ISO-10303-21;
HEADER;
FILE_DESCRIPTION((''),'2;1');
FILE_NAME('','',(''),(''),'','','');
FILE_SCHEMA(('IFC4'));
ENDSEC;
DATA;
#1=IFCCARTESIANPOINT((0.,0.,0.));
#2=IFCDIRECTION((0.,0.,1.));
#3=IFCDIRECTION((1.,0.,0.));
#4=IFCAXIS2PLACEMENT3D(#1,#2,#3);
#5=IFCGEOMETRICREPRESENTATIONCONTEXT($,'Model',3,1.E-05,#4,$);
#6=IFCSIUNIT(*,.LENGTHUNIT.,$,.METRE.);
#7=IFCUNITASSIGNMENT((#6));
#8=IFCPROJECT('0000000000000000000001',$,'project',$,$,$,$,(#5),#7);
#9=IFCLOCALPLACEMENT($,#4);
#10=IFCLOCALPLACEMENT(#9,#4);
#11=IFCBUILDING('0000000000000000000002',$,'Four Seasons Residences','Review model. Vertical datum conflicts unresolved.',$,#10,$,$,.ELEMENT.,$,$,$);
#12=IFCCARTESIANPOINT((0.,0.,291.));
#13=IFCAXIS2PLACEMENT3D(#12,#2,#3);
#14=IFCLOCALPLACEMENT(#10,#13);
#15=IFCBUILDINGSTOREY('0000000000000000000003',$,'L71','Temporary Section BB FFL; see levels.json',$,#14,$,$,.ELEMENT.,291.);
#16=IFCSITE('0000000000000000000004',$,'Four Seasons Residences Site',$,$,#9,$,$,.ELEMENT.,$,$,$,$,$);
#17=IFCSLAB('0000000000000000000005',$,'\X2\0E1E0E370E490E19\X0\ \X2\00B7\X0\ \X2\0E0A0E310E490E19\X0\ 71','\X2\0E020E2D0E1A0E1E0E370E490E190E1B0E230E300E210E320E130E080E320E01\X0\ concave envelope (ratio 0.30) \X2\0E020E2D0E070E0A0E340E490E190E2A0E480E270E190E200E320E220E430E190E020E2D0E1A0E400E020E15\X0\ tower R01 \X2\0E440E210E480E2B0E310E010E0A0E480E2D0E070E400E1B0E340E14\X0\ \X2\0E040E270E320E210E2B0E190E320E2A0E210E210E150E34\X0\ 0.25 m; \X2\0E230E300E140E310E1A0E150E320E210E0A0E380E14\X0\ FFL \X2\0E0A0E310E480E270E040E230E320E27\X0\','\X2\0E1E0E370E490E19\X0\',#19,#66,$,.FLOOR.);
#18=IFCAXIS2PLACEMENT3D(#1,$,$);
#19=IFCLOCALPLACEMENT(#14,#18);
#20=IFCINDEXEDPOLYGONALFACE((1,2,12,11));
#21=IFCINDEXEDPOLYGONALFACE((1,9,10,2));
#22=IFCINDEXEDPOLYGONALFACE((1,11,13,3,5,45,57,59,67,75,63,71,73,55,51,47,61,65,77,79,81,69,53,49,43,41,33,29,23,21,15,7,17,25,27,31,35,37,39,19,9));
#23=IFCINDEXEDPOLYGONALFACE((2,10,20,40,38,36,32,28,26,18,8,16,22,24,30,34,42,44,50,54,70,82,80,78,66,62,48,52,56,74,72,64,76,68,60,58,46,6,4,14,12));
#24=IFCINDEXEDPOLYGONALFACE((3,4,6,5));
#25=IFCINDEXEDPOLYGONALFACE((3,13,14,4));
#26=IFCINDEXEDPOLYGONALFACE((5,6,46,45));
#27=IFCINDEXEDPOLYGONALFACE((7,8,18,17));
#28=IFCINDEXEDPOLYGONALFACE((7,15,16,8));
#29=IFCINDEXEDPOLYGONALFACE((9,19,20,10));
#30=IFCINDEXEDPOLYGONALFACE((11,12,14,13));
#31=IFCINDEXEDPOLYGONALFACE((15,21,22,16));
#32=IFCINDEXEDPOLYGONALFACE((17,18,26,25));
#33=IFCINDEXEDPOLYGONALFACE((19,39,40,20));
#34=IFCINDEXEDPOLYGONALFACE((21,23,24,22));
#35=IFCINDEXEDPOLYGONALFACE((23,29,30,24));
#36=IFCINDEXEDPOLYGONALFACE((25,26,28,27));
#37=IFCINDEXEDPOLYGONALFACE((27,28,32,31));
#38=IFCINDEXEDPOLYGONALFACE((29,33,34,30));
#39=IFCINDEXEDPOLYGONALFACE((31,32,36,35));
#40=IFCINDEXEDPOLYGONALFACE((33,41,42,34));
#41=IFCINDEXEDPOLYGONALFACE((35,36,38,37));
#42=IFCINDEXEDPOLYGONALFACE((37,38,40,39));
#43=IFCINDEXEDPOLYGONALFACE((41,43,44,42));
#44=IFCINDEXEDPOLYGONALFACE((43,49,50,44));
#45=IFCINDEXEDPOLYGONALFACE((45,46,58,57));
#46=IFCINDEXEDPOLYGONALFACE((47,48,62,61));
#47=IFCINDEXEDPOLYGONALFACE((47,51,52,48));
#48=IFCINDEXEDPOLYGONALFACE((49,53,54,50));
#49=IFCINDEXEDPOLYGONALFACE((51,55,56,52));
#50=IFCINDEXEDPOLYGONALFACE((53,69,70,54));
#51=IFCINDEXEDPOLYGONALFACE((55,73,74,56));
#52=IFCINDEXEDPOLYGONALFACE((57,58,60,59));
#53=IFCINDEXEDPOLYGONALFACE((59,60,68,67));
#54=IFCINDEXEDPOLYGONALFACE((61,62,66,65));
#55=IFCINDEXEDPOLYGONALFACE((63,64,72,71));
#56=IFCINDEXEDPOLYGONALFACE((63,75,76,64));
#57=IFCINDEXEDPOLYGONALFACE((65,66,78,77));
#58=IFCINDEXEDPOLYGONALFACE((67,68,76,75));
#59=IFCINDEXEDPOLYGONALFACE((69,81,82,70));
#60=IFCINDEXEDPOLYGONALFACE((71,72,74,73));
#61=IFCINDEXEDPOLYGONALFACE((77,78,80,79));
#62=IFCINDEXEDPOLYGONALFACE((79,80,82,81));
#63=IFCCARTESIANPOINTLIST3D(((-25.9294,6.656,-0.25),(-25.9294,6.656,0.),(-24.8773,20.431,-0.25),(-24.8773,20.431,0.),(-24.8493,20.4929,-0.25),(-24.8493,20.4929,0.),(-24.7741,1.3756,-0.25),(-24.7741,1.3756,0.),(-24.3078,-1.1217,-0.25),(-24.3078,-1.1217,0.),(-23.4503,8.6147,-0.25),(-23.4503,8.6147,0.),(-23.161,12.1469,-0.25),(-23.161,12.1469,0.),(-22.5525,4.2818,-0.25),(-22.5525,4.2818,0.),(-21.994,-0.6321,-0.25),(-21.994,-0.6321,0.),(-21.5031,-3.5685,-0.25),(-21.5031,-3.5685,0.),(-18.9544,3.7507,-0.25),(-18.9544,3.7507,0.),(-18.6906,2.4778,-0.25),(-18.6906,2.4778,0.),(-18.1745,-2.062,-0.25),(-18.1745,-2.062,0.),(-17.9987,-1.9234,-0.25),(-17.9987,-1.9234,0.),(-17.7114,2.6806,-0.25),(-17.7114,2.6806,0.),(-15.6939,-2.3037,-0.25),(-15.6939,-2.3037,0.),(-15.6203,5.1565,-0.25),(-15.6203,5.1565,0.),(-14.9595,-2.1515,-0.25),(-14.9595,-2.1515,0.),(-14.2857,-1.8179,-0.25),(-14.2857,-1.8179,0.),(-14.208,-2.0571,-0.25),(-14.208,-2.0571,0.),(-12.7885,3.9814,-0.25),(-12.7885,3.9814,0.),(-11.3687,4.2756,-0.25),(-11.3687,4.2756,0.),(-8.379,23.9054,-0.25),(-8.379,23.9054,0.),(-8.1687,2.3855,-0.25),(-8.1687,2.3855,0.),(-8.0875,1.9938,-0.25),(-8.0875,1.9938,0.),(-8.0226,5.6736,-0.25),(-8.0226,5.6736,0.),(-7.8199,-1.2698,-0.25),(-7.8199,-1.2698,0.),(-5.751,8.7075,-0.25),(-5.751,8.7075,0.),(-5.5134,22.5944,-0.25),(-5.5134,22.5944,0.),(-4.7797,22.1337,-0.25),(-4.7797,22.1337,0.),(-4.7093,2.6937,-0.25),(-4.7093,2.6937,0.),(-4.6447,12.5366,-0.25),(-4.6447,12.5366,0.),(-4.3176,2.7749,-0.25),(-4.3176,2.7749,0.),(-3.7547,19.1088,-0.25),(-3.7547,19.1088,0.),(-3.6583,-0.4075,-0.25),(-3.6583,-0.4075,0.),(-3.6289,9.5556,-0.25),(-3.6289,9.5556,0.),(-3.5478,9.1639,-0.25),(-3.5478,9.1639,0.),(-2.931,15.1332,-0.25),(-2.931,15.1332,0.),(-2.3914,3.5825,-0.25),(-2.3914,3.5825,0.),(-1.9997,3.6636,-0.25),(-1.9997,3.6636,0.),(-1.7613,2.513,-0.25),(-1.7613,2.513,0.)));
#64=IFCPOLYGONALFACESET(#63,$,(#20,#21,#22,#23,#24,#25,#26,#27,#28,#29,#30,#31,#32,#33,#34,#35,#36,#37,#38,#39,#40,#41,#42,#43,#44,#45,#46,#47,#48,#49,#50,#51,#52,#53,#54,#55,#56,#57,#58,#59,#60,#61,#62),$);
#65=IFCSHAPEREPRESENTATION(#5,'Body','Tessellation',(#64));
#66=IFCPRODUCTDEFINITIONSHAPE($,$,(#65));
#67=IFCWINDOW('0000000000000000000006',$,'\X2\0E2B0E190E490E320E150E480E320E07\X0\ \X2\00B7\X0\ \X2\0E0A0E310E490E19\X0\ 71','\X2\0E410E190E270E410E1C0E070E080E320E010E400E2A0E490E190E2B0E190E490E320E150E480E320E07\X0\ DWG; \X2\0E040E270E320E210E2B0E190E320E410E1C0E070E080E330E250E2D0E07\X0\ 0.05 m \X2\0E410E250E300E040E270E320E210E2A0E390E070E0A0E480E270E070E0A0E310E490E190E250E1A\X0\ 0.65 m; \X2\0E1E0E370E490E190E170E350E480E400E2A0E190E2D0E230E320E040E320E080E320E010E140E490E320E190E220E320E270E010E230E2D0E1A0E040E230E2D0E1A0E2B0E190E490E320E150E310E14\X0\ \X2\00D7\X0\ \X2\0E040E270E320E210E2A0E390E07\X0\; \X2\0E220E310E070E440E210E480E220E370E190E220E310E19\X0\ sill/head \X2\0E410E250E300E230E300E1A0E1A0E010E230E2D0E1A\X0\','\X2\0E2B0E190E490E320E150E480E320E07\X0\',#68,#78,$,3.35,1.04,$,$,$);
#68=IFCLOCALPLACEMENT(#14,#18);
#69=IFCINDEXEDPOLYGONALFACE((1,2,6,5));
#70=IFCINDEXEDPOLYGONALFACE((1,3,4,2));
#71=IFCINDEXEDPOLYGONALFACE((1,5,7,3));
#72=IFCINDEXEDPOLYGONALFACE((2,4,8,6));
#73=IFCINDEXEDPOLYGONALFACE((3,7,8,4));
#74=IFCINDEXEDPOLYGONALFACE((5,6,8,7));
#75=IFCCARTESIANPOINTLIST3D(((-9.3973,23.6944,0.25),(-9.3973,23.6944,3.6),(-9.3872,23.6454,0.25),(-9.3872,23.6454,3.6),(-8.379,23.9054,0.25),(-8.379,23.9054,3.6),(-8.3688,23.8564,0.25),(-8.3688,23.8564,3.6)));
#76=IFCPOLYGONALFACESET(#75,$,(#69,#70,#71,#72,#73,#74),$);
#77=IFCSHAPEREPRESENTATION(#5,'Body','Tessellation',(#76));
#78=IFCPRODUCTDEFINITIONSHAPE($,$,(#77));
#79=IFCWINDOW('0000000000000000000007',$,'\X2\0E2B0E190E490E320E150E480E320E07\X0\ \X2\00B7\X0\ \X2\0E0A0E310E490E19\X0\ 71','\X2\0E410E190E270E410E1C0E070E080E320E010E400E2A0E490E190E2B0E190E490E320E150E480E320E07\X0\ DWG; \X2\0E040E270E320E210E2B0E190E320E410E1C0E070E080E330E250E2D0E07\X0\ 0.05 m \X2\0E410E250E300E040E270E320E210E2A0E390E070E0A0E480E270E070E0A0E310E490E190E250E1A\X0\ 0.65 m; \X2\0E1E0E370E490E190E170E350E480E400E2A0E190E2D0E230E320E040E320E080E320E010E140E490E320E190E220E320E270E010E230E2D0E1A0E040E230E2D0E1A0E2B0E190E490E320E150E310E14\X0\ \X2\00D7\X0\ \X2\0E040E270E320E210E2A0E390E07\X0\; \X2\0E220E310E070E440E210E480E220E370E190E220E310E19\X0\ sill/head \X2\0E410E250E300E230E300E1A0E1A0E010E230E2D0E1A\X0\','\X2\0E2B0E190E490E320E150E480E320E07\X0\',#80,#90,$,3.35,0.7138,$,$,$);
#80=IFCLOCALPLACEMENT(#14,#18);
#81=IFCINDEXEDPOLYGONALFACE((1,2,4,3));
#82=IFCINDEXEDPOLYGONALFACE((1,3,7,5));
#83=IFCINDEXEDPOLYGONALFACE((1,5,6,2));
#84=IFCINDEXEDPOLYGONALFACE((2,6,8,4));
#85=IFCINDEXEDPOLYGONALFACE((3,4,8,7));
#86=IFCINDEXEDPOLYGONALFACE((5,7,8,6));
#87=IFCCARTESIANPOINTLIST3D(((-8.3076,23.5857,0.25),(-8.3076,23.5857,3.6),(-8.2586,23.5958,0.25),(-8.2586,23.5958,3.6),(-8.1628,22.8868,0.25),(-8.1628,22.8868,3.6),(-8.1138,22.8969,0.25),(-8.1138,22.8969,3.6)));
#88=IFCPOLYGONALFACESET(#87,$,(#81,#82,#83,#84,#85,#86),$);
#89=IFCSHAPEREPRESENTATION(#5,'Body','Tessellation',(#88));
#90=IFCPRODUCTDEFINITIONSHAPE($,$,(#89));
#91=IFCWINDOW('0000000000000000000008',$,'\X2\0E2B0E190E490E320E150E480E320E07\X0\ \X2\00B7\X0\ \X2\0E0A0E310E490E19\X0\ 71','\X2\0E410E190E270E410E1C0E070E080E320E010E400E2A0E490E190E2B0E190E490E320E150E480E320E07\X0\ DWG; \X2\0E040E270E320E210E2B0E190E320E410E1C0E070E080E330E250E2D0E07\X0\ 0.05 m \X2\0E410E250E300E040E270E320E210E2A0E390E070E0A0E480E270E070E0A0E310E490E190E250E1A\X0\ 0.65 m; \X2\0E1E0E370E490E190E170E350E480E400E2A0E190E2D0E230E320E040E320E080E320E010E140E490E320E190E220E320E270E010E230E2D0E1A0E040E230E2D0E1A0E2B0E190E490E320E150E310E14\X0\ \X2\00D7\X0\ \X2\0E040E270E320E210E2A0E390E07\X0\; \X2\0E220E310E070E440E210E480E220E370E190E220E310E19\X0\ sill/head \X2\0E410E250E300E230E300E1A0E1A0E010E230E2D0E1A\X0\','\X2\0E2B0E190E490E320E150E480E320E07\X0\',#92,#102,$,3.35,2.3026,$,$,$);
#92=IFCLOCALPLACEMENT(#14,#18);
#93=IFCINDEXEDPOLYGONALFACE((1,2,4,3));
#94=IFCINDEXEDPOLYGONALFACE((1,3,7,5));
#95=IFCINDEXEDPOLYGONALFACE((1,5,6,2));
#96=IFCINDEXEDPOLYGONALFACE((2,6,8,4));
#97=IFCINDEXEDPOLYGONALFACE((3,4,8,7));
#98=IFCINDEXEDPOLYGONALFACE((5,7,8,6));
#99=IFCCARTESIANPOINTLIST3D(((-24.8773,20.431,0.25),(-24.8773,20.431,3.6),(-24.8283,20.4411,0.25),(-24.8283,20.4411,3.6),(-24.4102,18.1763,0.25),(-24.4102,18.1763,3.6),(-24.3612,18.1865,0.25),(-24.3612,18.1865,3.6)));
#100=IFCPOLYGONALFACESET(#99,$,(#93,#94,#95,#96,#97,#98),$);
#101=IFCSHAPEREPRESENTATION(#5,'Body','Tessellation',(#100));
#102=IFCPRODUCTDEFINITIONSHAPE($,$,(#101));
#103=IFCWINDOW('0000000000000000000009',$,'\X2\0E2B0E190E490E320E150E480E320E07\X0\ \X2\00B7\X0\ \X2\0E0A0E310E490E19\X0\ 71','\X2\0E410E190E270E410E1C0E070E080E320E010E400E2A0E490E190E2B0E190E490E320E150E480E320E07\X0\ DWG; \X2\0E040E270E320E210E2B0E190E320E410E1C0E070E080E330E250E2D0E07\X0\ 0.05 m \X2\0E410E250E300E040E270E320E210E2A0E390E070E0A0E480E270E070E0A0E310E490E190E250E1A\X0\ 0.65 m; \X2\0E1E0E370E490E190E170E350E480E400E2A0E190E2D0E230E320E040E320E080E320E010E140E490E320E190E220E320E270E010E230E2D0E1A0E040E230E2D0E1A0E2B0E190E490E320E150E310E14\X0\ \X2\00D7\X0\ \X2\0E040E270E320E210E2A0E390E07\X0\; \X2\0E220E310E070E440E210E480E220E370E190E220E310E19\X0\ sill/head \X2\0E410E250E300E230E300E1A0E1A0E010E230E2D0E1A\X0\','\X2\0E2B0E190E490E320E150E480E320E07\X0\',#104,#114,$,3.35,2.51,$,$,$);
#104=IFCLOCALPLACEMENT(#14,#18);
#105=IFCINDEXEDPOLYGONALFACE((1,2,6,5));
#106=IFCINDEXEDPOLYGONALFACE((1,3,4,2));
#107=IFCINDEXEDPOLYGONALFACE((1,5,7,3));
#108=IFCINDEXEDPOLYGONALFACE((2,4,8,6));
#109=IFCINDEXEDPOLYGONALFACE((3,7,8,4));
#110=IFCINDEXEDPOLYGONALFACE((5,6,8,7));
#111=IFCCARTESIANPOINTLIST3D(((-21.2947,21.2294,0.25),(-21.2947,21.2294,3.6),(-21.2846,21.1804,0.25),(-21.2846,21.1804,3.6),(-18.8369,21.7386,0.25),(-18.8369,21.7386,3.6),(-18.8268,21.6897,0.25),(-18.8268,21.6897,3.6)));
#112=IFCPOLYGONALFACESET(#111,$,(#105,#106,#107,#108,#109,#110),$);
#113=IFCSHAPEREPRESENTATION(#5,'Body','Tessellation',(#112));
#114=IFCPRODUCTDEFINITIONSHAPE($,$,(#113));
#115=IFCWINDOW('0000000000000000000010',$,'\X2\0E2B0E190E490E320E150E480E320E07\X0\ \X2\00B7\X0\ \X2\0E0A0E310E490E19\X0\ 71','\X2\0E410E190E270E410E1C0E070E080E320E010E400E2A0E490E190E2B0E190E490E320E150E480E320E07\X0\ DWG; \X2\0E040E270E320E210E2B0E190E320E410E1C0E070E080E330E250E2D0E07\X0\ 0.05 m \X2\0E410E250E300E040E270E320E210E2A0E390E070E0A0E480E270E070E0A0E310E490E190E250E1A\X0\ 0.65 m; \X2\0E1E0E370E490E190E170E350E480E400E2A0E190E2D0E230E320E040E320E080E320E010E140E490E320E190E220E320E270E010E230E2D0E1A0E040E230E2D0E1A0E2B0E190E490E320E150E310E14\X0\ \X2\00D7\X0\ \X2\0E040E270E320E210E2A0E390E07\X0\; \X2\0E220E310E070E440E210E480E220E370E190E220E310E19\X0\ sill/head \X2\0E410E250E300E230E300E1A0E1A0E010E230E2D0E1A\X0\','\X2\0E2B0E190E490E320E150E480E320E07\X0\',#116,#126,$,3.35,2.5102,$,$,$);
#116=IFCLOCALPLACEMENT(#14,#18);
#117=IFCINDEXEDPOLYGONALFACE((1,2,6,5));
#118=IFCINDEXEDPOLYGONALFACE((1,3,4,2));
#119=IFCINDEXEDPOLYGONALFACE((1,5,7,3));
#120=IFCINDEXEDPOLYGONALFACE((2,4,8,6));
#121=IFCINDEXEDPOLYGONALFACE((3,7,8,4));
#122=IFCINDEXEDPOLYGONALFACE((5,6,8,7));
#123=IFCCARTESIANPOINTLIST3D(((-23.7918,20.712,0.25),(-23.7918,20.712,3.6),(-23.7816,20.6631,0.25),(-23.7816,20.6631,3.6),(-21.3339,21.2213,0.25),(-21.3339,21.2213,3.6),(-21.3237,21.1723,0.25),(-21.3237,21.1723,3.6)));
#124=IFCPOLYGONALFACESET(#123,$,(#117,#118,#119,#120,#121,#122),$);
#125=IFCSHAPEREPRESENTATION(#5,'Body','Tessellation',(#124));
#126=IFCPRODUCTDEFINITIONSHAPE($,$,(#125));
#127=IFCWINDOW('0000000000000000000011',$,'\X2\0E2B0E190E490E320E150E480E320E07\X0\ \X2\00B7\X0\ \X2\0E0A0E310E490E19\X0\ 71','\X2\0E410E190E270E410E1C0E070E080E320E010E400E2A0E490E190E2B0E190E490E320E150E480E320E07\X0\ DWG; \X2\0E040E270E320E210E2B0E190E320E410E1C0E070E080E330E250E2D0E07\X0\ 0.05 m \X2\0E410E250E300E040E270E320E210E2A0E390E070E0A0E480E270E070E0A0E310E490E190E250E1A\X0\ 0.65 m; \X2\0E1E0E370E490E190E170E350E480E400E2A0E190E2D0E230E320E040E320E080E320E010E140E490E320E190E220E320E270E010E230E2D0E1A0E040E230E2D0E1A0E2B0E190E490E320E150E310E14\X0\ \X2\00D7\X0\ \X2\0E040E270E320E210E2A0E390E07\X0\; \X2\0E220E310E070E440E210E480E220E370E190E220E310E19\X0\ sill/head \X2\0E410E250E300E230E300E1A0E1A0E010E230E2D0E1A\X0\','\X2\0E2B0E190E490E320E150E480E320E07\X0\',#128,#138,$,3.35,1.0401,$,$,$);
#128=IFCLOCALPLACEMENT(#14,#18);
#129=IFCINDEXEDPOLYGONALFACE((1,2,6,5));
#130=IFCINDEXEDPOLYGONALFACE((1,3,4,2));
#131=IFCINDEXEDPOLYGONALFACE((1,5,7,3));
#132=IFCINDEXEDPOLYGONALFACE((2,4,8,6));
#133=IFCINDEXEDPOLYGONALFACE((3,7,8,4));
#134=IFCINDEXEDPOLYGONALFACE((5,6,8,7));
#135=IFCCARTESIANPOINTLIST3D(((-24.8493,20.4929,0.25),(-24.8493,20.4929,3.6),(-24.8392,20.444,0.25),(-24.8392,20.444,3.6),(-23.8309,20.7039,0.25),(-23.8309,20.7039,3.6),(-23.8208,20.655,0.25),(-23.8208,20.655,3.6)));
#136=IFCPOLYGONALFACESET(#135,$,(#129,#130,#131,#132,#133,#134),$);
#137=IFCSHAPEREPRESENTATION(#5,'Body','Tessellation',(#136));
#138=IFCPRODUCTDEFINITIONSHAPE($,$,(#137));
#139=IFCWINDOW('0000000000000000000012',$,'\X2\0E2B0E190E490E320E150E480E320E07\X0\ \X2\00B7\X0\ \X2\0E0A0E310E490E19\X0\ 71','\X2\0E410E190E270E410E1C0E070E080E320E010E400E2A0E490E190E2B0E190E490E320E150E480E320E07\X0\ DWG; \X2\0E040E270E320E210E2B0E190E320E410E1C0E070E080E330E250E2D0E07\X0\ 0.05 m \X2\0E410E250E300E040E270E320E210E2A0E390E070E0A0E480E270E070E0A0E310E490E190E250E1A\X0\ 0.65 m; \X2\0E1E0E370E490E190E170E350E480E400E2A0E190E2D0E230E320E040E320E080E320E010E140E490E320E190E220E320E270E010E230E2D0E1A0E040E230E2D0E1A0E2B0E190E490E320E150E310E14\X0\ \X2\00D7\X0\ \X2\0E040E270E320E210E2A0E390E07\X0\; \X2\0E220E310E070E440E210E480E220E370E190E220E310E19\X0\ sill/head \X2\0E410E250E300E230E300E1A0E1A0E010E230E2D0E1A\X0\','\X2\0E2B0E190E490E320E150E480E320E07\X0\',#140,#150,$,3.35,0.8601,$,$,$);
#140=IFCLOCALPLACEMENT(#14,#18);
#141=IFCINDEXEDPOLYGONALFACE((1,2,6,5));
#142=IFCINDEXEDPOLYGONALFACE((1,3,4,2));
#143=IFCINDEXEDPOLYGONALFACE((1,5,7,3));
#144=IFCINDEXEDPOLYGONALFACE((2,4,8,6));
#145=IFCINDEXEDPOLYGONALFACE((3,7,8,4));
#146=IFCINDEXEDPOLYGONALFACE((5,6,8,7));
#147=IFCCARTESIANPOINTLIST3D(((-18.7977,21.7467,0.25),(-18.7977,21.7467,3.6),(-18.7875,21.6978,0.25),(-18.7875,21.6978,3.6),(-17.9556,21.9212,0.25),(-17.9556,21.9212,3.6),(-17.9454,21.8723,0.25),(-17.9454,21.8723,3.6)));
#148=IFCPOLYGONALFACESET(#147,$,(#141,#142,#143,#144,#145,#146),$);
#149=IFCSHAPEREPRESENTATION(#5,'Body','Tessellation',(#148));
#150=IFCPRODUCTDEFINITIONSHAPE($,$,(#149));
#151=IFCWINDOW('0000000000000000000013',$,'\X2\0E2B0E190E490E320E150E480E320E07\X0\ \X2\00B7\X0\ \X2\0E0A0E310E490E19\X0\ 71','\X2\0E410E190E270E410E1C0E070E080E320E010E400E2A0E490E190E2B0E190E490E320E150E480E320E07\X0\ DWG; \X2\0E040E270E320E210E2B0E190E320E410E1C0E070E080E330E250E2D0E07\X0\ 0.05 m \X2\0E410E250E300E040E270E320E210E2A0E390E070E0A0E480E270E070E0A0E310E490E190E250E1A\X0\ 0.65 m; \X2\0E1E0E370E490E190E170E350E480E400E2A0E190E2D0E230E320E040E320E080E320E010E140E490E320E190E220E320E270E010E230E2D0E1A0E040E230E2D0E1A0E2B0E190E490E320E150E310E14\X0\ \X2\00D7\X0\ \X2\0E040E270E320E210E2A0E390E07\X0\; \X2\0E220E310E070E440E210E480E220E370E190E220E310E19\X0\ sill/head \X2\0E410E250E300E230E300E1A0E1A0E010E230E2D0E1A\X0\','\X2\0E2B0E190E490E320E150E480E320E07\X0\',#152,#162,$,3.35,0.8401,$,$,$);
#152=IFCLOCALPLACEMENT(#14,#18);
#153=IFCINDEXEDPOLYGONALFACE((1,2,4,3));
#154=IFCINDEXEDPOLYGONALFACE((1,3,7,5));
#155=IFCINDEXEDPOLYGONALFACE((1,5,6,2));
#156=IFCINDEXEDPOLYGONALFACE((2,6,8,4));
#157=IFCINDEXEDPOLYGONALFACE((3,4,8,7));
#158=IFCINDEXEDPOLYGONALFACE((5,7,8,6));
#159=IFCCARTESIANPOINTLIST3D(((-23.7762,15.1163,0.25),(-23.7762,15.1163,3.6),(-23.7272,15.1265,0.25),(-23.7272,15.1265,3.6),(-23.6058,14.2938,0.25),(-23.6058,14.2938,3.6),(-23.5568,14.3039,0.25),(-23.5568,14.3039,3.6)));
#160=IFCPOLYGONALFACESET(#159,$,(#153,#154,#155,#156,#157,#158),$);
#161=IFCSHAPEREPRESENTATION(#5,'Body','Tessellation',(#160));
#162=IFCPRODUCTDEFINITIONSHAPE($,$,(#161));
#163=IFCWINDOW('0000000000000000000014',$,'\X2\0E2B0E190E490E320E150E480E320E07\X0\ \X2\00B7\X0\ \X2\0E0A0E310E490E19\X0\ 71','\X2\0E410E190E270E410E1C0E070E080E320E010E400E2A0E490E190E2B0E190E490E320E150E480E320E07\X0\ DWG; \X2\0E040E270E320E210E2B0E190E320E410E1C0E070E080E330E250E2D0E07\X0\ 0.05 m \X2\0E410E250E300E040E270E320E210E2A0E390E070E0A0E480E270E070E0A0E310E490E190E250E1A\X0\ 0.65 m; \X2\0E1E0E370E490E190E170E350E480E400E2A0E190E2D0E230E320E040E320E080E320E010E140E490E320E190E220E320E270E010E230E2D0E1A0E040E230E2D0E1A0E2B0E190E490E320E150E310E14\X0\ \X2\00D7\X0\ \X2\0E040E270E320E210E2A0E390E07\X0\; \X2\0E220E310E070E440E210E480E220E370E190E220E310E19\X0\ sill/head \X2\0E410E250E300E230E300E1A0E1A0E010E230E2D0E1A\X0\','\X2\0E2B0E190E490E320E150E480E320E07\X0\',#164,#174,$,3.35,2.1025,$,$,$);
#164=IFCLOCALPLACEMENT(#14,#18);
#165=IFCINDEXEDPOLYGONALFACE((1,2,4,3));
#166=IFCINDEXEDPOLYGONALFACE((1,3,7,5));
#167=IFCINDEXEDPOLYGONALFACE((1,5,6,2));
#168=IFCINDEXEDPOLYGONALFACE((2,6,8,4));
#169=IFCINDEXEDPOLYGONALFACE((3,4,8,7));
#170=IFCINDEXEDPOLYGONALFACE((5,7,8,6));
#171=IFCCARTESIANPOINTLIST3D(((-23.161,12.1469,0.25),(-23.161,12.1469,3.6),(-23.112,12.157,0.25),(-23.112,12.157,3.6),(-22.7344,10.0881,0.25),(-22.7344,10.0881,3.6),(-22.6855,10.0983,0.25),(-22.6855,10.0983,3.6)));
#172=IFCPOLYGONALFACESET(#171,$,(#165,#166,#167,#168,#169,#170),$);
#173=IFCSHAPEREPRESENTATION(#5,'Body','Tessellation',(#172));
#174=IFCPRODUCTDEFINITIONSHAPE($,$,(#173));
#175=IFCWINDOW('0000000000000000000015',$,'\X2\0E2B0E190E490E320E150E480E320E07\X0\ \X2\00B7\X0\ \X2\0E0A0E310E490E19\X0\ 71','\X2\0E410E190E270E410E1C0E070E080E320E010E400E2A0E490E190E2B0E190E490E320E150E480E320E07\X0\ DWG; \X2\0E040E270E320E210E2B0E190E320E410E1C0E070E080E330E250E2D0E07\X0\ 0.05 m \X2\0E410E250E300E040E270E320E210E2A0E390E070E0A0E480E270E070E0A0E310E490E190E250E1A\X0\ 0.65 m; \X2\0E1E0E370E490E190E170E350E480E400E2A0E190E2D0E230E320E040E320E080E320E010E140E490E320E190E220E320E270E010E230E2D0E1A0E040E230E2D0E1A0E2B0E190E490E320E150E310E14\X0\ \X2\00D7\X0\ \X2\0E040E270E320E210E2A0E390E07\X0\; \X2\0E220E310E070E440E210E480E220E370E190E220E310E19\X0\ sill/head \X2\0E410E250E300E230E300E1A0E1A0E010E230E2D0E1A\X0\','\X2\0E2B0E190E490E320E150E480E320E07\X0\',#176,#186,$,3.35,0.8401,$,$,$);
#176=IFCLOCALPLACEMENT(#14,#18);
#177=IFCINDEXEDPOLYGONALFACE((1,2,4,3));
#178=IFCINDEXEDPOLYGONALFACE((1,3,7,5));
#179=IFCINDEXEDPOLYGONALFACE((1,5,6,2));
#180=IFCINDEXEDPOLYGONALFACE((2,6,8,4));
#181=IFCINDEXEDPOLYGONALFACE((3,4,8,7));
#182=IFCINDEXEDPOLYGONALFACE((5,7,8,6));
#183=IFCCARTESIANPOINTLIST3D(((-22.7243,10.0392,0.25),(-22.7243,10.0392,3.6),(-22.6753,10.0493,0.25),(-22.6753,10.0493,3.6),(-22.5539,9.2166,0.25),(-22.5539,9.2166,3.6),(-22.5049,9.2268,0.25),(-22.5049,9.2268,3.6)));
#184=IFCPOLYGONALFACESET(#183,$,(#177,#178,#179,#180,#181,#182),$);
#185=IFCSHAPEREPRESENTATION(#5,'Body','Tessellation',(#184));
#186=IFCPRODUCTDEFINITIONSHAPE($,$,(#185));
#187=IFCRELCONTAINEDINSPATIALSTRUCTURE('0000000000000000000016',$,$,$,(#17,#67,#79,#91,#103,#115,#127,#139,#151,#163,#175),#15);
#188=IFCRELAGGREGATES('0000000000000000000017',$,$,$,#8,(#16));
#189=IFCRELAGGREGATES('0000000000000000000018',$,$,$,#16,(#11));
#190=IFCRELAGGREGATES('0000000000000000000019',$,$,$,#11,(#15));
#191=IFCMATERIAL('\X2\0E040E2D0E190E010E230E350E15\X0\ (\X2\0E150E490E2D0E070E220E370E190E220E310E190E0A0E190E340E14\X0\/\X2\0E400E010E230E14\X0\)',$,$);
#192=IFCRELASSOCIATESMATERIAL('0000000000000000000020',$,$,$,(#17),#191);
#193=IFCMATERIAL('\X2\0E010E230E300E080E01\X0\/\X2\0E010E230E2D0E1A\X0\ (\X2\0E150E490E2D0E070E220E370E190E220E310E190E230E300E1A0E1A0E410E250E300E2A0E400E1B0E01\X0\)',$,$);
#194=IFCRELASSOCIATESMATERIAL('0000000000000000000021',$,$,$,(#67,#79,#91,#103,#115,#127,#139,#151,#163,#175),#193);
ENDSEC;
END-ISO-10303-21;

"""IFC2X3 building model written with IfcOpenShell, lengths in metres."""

from ifc_helpers import new_model, si_unit, frame, origin_with_axes, place, context, project, spatial, polyline, outline, extrude, material, element, save


model = new_model("IFC2X3")

# Units and contexts
model_context = context("Model", 3, precision=1e-05, world=origin_with_axes())
ifc_project = project(units=[si_unit("LENGTHUNIT", "METRE")], contexts=[model_context])

# Site, building, storey
site_placement = place(None, origin_with_axes())
site = spatial("IfcSite", under=ifc_project, at=site_placement, Name="Four Seasons Residences Site", CompositionType="ELEMENT")
building_placement = place(site_placement, origin_with_axes())
building = spatial("IfcBuilding", under=site, at=building_placement, Name="Four Seasons Residences", Description="Review model. Vertical datum conflicts unresolved.", CompositionType="ELEMENT")
storey_placement = place(building_placement, frame((0.0, 0.0, 291.0), z_axis=(0.0, 0.0, 1.0), x_axis=(1.0, 0.0, 0.0)))
storey = spatial("IfcBuildingStorey", under=building, at=storey_placement, Name="L71", Description="Temporary Section BB FFL; see levels.json", CompositionType="ELEMENT", Elevation=291.0)

# Slab
ifc_material_1 = material(Name="คอนกรีต (ต้องยืนยันชนิด/เกรด)")
slab_placement = place(storey_placement, origin_with_axes())
element("IfcSlab", 1, at=slab_placement, inside=storey, material=ifc_material_1, Name="พื้น · ชั้น 71", Description="ขอบพื้นประมาณจาก concave envelope (ratio 0.30) ของชิ้นส่วนภายในขอบเขต tower R01 ไม่หักช่องเปิด ความหนาสมมติ 0.25 m; ระดับตามชุด FFL ชั่วคราว", ObjectType="พื้น", PredefinedType="FLOOR", context=model_context, shape_type="SweptSolid", body=[
    extrude(outline(polyline([(-24.8773, 20.431), (-24.8493, 20.4929), (-8.379, 23.9054), (-5.5134, 22.5944), (-4.7797, 22.1337), (-3.7547, 19.1088), (-2.931, 15.1332), (-4.6447, 12.5366), (-3.6289, 9.5556), (-3.5478, 9.1639), (-5.751, 8.7075), (-8.0226, 5.6736), (-8.1687, 2.3855), (-4.7093, 2.6937), (-4.3176, 2.7749), (-2.3914, 3.5825), (-1.9997, 3.6636), (-1.7613, 2.513), (-3.6583, -0.4075), (-7.8199, -1.2698), (-8.0875, 1.9938), (-11.3687, 4.2756), (-12.7885, 3.9814), (-15.6203, 5.1565), (-17.7114, 2.6806), (-18.6906, 2.4778), (-18.9544, 3.7507), (-22.5525, 4.2818), (-24.7741, 1.3756), (-21.994, -0.6321), (-18.1745, -2.062), (-17.9987, -1.9234), (-15.6939, -2.3037), (-14.9595, -2.1515), (-14.2857, -1.8179), (-14.208, -2.0571), (-21.5031, -3.5685), (-24.3078, -1.1217), (-25.9294, 6.656), (-23.4503, 8.6147), (-23.161, 12.1469), (-24.8773, 20.431)])), frame((0.0, 0.0, -0.25), z_axis=(0.0, 0.0, 1.0), x_axis=(1.0, 0.0, 0.0)), (0.0, 0.0, 1.0), 0.25),
])

# Windows
ifc_material_2 = material(Name="กระจก/กรอบ (ต้องยืนยันระบบและสเปก)")
window_1_placement = place(storey_placement, origin_with_axes())
element("IfcWindow", 2, at=window_1_placement, inside=storey, material=ifc_material_2, Name="หน้าต่าง · ชั้น 71", Description="แนวแผงจากเส้นหน้าต่าง DWG; ความหนาแผงจำลอง 0.05 m และความสูงช่วงชั้นลบ 0.65 m; พื้นที่เสนอราคาจากด้านยาวกรอบครอบหน้าตัด × ความสูง; ยังไม่ยืนยัน sill/head และระบบกรอบ", ObjectType="หน้าต่าง", OverallHeight=3.35, OverallWidth=1.04, context=model_context, shape_type="SweptSolid", body=[
    extrude(outline(polyline([(-8.379, 23.9054), (-8.3688, 23.8564), (-9.3872, 23.6454), (-9.3973, 23.6944), (-8.379, 23.9054)])), frame((0.0, 0.0, 0.25), z_axis=(0.0, 0.0, 1.0), x_axis=(1.0, 0.0, 0.0)), (0.0, 0.0, 1.0), 3.35),
])
window_2_placement = place(storey_placement, origin_with_axes())
element("IfcWindow", 3, at=window_2_placement, inside=storey, material=ifc_material_2, Name="หน้าต่าง · ชั้น 71", Description="แนวแผงจากเส้นหน้าต่าง DWG; ความหนาแผงจำลอง 0.05 m และความสูงช่วงชั้นลบ 0.65 m; พื้นที่เสนอราคาจากด้านยาวกรอบครอบหน้าตัด × ความสูง; ยังไม่ยืนยัน sill/head และระบบกรอบ", ObjectType="หน้าต่าง", OverallHeight=3.35, OverallWidth=0.7138, context=model_context, shape_type="SweptSolid", body=[
    extrude(outline(polyline([(-8.3076, 23.5857), (-8.2586, 23.5958), (-8.1138, 22.8969), (-8.1628, 22.8868), (-8.3076, 23.5857)])), frame((0.0, 0.0, 0.25), z_axis=(0.0, 0.0, 1.0), x_axis=(1.0, 0.0, 0.0)), (0.0, 0.0, 1.0), 3.35),
])
window_3_placement = place(storey_placement, origin_with_axes())
element("IfcWindow", 4, at=window_3_placement, inside=storey, material=ifc_material_2, Name="หน้าต่าง · ชั้น 71", Description="แนวแผงจากเส้นหน้าต่าง DWG; ความหนาแผงจำลอง 0.05 m และความสูงช่วงชั้นลบ 0.65 m; พื้นที่เสนอราคาจากด้านยาวกรอบครอบหน้าตัด × ความสูง; ยังไม่ยืนยัน sill/head และระบบกรอบ", ObjectType="หน้าต่าง", OverallHeight=3.35, OverallWidth=2.3026, context=model_context, shape_type="SweptSolid", body=[
    extrude(outline(polyline([(-24.8773, 20.431), (-24.8283, 20.4411), (-24.3612, 18.1865), (-24.4102, 18.1763), (-24.8773, 20.431)])), frame((0.0, 0.0, 0.25), z_axis=(0.0, 0.0, 1.0), x_axis=(1.0, 0.0, 0.0)), (0.0, 0.0, 1.0), 3.35),
])
window_4_placement = place(storey_placement, origin_with_axes())
element("IfcWindow", 5, at=window_4_placement, inside=storey, material=ifc_material_2, Name="หน้าต่าง · ชั้น 71", Description="แนวแผงจากเส้นหน้าต่าง DWG; ความหนาแผงจำลอง 0.05 m และความสูงช่วงชั้นลบ 0.65 m; พื้นที่เสนอราคาจากด้านยาวกรอบครอบหน้าตัด × ความสูง; ยังไม่ยืนยัน sill/head และระบบกรอบ", ObjectType="หน้าต่าง", OverallHeight=3.35, OverallWidth=2.51, context=model_context, shape_type="SweptSolid", body=[
    extrude(outline(polyline([(-21.2846, 21.1804), (-21.2947, 21.2294), (-18.8369, 21.7386), (-18.8268, 21.6897), (-21.2846, 21.1804)])), frame((0.0, 0.0, 0.25), z_axis=(0.0, 0.0, 1.0), x_axis=(1.0, 0.0, 0.0)), (0.0, 0.0, 1.0), 3.35),
])
window_5_placement = place(storey_placement, origin_with_axes())
element("IfcWindow", 6, at=window_5_placement, inside=storey, material=ifc_material_2, Name="หน้าต่าง · ชั้น 71", Description="แนวแผงจากเส้นหน้าต่าง DWG; ความหนาแผงจำลอง 0.05 m และความสูงช่วงชั้นลบ 0.65 m; พื้นที่เสนอราคาจากด้านยาวกรอบครอบหน้าตัด × ความสูง; ยังไม่ยืนยัน sill/head และระบบกรอบ", ObjectType="หน้าต่าง", OverallHeight=3.35, OverallWidth=2.5102, context=model_context, shape_type="SweptSolid", body=[
    extrude(outline(polyline([(-23.7816, 20.6631), (-23.7918, 20.712), (-21.3339, 21.2213), (-21.3237, 21.1723), (-23.7816, 20.6631)])), frame((0.0, 0.0, 0.25), z_axis=(0.0, 0.0, 1.0), x_axis=(1.0, 0.0, 0.0)), (0.0, 0.0, 1.0), 3.35),
])
window_6_placement = place(storey_placement, origin_with_axes())
element("IfcWindow", 7, at=window_6_placement, inside=storey, material=ifc_material_2, Name="หน้าต่าง · ชั้น 71", Description="แนวแผงจากเส้นหน้าต่าง DWG; ความหนาแผงจำลอง 0.05 m และความสูงช่วงชั้นลบ 0.65 m; พื้นที่เสนอราคาจากด้านยาวกรอบครอบหน้าตัด × ความสูง; ยังไม่ยืนยัน sill/head และระบบกรอบ", ObjectType="หน้าต่าง", OverallHeight=3.35, OverallWidth=1.0401, context=model_context, shape_type="SweptSolid", body=[
    extrude(outline(polyline([(-24.8392, 20.444), (-24.8493, 20.4929), (-23.8309, 20.7039), (-23.8208, 20.655), (-24.8392, 20.444)])), frame((0.0, 0.0, 0.25), z_axis=(0.0, 0.0, 1.0), x_axis=(1.0, 0.0, 0.0)), (0.0, 0.0, 1.0), 3.35),
])
window_7_placement = place(storey_placement, origin_with_axes())
element("IfcWindow", 8, at=window_7_placement, inside=storey, material=ifc_material_2, Name="หน้าต่าง · ชั้น 71", Description="แนวแผงจากเส้นหน้าต่าง DWG; ความหนาแผงจำลอง 0.05 m และความสูงช่วงชั้นลบ 0.65 m; พื้นที่เสนอราคาจากด้านยาวกรอบครอบหน้าตัด × ความสูง; ยังไม่ยืนยัน sill/head และระบบกรอบ", ObjectType="หน้าต่าง", OverallHeight=3.35, OverallWidth=0.8601, context=model_context, shape_type="SweptSolid", body=[
    extrude(outline(polyline([(-17.9556, 21.9212), (-17.9454, 21.8723), (-18.7875, 21.6978), (-18.7977, 21.7467), (-17.9556, 21.9212)])), frame((0.0, 0.0, 0.25), z_axis=(0.0, 0.0, 1.0), x_axis=(1.0, 0.0, 0.0)), (0.0, 0.0, 1.0), 3.35),
])
window_8_placement = place(storey_placement, origin_with_axes())
element("IfcWindow", 9, at=window_8_placement, inside=storey, material=ifc_material_2, Name="หน้าต่าง · ชั้น 71", Description="แนวแผงจากเส้นหน้าต่าง DWG; ความหนาแผงจำลอง 0.05 m และความสูงช่วงชั้นลบ 0.65 m; พื้นที่เสนอราคาจากด้านยาวกรอบครอบหน้าตัด × ความสูง; ยังไม่ยืนยัน sill/head และระบบกรอบ", ObjectType="หน้าต่าง", OverallHeight=3.35, OverallWidth=0.8401, context=model_context, shape_type="SweptSolid", body=[
    extrude(outline(polyline([(-23.7762, 15.1163), (-23.7272, 15.1265), (-23.5568, 14.3039), (-23.6058, 14.2938), (-23.7762, 15.1163)])), frame((0.0, 0.0, 0.25), z_axis=(0.0, 0.0, 1.0), x_axis=(1.0, 0.0, 0.0)), (0.0, 0.0, 1.0), 3.35),
])
window_9_placement = place(storey_placement, origin_with_axes())
element("IfcWindow", 10, at=window_9_placement, inside=storey, material=ifc_material_2, Name="หน้าต่าง · ชั้น 71", Description="แนวแผงจากเส้นหน้าต่าง DWG; ความหนาแผงจำลอง 0.05 m และความสูงช่วงชั้นลบ 0.65 m; พื้นที่เสนอราคาจากด้านยาวกรอบครอบหน้าตัด × ความสูง; ยังไม่ยืนยัน sill/head และระบบกรอบ", ObjectType="หน้าต่าง", OverallHeight=3.35, OverallWidth=2.1025, context=model_context, shape_type="SweptSolid", body=[
    extrude(outline(polyline([(-23.161, 12.1469), (-23.112, 12.157), (-22.6855, 10.0983), (-22.7344, 10.0881), (-23.161, 12.1469)])), frame((0.0, 0.0, 0.25), z_axis=(0.0, 0.0, 1.0), x_axis=(1.0, 0.0, 0.0)), (0.0, 0.0, 1.0), 3.35),
])
window_10_placement = place(storey_placement, origin_with_axes())
element("IfcWindow", 11, at=window_10_placement, inside=storey, material=ifc_material_2, Name="หน้าต่าง · ชั้น 71", Description="แนวแผงจากเส้นหน้าต่าง DWG; ความหนาแผงจำลอง 0.05 m และความสูงช่วงชั้นลบ 0.65 m; พื้นที่เสนอราคาจากด้านยาวกรอบครอบหน้าตัด × ความสูง; ยังไม่ยืนยัน sill/head และระบบกรอบ", ObjectType="หน้าต่าง", OverallHeight=3.35, OverallWidth=0.8401, context=model_context, shape_type="SweptSolid", body=[
    extrude(outline(polyline([(-22.7243, 10.0392), (-22.6753, 10.0493), (-22.5049, 9.2268), (-22.5539, 9.2166), (-22.7243, 10.0392)])), frame((0.0, 0.0, 0.25), z_axis=(0.0, 0.0, 1.0), x_axis=(1.0, 0.0, 0.0)), (0.0, 0.0, 1.0), 3.35),
])

save(model, "model.ifc")
